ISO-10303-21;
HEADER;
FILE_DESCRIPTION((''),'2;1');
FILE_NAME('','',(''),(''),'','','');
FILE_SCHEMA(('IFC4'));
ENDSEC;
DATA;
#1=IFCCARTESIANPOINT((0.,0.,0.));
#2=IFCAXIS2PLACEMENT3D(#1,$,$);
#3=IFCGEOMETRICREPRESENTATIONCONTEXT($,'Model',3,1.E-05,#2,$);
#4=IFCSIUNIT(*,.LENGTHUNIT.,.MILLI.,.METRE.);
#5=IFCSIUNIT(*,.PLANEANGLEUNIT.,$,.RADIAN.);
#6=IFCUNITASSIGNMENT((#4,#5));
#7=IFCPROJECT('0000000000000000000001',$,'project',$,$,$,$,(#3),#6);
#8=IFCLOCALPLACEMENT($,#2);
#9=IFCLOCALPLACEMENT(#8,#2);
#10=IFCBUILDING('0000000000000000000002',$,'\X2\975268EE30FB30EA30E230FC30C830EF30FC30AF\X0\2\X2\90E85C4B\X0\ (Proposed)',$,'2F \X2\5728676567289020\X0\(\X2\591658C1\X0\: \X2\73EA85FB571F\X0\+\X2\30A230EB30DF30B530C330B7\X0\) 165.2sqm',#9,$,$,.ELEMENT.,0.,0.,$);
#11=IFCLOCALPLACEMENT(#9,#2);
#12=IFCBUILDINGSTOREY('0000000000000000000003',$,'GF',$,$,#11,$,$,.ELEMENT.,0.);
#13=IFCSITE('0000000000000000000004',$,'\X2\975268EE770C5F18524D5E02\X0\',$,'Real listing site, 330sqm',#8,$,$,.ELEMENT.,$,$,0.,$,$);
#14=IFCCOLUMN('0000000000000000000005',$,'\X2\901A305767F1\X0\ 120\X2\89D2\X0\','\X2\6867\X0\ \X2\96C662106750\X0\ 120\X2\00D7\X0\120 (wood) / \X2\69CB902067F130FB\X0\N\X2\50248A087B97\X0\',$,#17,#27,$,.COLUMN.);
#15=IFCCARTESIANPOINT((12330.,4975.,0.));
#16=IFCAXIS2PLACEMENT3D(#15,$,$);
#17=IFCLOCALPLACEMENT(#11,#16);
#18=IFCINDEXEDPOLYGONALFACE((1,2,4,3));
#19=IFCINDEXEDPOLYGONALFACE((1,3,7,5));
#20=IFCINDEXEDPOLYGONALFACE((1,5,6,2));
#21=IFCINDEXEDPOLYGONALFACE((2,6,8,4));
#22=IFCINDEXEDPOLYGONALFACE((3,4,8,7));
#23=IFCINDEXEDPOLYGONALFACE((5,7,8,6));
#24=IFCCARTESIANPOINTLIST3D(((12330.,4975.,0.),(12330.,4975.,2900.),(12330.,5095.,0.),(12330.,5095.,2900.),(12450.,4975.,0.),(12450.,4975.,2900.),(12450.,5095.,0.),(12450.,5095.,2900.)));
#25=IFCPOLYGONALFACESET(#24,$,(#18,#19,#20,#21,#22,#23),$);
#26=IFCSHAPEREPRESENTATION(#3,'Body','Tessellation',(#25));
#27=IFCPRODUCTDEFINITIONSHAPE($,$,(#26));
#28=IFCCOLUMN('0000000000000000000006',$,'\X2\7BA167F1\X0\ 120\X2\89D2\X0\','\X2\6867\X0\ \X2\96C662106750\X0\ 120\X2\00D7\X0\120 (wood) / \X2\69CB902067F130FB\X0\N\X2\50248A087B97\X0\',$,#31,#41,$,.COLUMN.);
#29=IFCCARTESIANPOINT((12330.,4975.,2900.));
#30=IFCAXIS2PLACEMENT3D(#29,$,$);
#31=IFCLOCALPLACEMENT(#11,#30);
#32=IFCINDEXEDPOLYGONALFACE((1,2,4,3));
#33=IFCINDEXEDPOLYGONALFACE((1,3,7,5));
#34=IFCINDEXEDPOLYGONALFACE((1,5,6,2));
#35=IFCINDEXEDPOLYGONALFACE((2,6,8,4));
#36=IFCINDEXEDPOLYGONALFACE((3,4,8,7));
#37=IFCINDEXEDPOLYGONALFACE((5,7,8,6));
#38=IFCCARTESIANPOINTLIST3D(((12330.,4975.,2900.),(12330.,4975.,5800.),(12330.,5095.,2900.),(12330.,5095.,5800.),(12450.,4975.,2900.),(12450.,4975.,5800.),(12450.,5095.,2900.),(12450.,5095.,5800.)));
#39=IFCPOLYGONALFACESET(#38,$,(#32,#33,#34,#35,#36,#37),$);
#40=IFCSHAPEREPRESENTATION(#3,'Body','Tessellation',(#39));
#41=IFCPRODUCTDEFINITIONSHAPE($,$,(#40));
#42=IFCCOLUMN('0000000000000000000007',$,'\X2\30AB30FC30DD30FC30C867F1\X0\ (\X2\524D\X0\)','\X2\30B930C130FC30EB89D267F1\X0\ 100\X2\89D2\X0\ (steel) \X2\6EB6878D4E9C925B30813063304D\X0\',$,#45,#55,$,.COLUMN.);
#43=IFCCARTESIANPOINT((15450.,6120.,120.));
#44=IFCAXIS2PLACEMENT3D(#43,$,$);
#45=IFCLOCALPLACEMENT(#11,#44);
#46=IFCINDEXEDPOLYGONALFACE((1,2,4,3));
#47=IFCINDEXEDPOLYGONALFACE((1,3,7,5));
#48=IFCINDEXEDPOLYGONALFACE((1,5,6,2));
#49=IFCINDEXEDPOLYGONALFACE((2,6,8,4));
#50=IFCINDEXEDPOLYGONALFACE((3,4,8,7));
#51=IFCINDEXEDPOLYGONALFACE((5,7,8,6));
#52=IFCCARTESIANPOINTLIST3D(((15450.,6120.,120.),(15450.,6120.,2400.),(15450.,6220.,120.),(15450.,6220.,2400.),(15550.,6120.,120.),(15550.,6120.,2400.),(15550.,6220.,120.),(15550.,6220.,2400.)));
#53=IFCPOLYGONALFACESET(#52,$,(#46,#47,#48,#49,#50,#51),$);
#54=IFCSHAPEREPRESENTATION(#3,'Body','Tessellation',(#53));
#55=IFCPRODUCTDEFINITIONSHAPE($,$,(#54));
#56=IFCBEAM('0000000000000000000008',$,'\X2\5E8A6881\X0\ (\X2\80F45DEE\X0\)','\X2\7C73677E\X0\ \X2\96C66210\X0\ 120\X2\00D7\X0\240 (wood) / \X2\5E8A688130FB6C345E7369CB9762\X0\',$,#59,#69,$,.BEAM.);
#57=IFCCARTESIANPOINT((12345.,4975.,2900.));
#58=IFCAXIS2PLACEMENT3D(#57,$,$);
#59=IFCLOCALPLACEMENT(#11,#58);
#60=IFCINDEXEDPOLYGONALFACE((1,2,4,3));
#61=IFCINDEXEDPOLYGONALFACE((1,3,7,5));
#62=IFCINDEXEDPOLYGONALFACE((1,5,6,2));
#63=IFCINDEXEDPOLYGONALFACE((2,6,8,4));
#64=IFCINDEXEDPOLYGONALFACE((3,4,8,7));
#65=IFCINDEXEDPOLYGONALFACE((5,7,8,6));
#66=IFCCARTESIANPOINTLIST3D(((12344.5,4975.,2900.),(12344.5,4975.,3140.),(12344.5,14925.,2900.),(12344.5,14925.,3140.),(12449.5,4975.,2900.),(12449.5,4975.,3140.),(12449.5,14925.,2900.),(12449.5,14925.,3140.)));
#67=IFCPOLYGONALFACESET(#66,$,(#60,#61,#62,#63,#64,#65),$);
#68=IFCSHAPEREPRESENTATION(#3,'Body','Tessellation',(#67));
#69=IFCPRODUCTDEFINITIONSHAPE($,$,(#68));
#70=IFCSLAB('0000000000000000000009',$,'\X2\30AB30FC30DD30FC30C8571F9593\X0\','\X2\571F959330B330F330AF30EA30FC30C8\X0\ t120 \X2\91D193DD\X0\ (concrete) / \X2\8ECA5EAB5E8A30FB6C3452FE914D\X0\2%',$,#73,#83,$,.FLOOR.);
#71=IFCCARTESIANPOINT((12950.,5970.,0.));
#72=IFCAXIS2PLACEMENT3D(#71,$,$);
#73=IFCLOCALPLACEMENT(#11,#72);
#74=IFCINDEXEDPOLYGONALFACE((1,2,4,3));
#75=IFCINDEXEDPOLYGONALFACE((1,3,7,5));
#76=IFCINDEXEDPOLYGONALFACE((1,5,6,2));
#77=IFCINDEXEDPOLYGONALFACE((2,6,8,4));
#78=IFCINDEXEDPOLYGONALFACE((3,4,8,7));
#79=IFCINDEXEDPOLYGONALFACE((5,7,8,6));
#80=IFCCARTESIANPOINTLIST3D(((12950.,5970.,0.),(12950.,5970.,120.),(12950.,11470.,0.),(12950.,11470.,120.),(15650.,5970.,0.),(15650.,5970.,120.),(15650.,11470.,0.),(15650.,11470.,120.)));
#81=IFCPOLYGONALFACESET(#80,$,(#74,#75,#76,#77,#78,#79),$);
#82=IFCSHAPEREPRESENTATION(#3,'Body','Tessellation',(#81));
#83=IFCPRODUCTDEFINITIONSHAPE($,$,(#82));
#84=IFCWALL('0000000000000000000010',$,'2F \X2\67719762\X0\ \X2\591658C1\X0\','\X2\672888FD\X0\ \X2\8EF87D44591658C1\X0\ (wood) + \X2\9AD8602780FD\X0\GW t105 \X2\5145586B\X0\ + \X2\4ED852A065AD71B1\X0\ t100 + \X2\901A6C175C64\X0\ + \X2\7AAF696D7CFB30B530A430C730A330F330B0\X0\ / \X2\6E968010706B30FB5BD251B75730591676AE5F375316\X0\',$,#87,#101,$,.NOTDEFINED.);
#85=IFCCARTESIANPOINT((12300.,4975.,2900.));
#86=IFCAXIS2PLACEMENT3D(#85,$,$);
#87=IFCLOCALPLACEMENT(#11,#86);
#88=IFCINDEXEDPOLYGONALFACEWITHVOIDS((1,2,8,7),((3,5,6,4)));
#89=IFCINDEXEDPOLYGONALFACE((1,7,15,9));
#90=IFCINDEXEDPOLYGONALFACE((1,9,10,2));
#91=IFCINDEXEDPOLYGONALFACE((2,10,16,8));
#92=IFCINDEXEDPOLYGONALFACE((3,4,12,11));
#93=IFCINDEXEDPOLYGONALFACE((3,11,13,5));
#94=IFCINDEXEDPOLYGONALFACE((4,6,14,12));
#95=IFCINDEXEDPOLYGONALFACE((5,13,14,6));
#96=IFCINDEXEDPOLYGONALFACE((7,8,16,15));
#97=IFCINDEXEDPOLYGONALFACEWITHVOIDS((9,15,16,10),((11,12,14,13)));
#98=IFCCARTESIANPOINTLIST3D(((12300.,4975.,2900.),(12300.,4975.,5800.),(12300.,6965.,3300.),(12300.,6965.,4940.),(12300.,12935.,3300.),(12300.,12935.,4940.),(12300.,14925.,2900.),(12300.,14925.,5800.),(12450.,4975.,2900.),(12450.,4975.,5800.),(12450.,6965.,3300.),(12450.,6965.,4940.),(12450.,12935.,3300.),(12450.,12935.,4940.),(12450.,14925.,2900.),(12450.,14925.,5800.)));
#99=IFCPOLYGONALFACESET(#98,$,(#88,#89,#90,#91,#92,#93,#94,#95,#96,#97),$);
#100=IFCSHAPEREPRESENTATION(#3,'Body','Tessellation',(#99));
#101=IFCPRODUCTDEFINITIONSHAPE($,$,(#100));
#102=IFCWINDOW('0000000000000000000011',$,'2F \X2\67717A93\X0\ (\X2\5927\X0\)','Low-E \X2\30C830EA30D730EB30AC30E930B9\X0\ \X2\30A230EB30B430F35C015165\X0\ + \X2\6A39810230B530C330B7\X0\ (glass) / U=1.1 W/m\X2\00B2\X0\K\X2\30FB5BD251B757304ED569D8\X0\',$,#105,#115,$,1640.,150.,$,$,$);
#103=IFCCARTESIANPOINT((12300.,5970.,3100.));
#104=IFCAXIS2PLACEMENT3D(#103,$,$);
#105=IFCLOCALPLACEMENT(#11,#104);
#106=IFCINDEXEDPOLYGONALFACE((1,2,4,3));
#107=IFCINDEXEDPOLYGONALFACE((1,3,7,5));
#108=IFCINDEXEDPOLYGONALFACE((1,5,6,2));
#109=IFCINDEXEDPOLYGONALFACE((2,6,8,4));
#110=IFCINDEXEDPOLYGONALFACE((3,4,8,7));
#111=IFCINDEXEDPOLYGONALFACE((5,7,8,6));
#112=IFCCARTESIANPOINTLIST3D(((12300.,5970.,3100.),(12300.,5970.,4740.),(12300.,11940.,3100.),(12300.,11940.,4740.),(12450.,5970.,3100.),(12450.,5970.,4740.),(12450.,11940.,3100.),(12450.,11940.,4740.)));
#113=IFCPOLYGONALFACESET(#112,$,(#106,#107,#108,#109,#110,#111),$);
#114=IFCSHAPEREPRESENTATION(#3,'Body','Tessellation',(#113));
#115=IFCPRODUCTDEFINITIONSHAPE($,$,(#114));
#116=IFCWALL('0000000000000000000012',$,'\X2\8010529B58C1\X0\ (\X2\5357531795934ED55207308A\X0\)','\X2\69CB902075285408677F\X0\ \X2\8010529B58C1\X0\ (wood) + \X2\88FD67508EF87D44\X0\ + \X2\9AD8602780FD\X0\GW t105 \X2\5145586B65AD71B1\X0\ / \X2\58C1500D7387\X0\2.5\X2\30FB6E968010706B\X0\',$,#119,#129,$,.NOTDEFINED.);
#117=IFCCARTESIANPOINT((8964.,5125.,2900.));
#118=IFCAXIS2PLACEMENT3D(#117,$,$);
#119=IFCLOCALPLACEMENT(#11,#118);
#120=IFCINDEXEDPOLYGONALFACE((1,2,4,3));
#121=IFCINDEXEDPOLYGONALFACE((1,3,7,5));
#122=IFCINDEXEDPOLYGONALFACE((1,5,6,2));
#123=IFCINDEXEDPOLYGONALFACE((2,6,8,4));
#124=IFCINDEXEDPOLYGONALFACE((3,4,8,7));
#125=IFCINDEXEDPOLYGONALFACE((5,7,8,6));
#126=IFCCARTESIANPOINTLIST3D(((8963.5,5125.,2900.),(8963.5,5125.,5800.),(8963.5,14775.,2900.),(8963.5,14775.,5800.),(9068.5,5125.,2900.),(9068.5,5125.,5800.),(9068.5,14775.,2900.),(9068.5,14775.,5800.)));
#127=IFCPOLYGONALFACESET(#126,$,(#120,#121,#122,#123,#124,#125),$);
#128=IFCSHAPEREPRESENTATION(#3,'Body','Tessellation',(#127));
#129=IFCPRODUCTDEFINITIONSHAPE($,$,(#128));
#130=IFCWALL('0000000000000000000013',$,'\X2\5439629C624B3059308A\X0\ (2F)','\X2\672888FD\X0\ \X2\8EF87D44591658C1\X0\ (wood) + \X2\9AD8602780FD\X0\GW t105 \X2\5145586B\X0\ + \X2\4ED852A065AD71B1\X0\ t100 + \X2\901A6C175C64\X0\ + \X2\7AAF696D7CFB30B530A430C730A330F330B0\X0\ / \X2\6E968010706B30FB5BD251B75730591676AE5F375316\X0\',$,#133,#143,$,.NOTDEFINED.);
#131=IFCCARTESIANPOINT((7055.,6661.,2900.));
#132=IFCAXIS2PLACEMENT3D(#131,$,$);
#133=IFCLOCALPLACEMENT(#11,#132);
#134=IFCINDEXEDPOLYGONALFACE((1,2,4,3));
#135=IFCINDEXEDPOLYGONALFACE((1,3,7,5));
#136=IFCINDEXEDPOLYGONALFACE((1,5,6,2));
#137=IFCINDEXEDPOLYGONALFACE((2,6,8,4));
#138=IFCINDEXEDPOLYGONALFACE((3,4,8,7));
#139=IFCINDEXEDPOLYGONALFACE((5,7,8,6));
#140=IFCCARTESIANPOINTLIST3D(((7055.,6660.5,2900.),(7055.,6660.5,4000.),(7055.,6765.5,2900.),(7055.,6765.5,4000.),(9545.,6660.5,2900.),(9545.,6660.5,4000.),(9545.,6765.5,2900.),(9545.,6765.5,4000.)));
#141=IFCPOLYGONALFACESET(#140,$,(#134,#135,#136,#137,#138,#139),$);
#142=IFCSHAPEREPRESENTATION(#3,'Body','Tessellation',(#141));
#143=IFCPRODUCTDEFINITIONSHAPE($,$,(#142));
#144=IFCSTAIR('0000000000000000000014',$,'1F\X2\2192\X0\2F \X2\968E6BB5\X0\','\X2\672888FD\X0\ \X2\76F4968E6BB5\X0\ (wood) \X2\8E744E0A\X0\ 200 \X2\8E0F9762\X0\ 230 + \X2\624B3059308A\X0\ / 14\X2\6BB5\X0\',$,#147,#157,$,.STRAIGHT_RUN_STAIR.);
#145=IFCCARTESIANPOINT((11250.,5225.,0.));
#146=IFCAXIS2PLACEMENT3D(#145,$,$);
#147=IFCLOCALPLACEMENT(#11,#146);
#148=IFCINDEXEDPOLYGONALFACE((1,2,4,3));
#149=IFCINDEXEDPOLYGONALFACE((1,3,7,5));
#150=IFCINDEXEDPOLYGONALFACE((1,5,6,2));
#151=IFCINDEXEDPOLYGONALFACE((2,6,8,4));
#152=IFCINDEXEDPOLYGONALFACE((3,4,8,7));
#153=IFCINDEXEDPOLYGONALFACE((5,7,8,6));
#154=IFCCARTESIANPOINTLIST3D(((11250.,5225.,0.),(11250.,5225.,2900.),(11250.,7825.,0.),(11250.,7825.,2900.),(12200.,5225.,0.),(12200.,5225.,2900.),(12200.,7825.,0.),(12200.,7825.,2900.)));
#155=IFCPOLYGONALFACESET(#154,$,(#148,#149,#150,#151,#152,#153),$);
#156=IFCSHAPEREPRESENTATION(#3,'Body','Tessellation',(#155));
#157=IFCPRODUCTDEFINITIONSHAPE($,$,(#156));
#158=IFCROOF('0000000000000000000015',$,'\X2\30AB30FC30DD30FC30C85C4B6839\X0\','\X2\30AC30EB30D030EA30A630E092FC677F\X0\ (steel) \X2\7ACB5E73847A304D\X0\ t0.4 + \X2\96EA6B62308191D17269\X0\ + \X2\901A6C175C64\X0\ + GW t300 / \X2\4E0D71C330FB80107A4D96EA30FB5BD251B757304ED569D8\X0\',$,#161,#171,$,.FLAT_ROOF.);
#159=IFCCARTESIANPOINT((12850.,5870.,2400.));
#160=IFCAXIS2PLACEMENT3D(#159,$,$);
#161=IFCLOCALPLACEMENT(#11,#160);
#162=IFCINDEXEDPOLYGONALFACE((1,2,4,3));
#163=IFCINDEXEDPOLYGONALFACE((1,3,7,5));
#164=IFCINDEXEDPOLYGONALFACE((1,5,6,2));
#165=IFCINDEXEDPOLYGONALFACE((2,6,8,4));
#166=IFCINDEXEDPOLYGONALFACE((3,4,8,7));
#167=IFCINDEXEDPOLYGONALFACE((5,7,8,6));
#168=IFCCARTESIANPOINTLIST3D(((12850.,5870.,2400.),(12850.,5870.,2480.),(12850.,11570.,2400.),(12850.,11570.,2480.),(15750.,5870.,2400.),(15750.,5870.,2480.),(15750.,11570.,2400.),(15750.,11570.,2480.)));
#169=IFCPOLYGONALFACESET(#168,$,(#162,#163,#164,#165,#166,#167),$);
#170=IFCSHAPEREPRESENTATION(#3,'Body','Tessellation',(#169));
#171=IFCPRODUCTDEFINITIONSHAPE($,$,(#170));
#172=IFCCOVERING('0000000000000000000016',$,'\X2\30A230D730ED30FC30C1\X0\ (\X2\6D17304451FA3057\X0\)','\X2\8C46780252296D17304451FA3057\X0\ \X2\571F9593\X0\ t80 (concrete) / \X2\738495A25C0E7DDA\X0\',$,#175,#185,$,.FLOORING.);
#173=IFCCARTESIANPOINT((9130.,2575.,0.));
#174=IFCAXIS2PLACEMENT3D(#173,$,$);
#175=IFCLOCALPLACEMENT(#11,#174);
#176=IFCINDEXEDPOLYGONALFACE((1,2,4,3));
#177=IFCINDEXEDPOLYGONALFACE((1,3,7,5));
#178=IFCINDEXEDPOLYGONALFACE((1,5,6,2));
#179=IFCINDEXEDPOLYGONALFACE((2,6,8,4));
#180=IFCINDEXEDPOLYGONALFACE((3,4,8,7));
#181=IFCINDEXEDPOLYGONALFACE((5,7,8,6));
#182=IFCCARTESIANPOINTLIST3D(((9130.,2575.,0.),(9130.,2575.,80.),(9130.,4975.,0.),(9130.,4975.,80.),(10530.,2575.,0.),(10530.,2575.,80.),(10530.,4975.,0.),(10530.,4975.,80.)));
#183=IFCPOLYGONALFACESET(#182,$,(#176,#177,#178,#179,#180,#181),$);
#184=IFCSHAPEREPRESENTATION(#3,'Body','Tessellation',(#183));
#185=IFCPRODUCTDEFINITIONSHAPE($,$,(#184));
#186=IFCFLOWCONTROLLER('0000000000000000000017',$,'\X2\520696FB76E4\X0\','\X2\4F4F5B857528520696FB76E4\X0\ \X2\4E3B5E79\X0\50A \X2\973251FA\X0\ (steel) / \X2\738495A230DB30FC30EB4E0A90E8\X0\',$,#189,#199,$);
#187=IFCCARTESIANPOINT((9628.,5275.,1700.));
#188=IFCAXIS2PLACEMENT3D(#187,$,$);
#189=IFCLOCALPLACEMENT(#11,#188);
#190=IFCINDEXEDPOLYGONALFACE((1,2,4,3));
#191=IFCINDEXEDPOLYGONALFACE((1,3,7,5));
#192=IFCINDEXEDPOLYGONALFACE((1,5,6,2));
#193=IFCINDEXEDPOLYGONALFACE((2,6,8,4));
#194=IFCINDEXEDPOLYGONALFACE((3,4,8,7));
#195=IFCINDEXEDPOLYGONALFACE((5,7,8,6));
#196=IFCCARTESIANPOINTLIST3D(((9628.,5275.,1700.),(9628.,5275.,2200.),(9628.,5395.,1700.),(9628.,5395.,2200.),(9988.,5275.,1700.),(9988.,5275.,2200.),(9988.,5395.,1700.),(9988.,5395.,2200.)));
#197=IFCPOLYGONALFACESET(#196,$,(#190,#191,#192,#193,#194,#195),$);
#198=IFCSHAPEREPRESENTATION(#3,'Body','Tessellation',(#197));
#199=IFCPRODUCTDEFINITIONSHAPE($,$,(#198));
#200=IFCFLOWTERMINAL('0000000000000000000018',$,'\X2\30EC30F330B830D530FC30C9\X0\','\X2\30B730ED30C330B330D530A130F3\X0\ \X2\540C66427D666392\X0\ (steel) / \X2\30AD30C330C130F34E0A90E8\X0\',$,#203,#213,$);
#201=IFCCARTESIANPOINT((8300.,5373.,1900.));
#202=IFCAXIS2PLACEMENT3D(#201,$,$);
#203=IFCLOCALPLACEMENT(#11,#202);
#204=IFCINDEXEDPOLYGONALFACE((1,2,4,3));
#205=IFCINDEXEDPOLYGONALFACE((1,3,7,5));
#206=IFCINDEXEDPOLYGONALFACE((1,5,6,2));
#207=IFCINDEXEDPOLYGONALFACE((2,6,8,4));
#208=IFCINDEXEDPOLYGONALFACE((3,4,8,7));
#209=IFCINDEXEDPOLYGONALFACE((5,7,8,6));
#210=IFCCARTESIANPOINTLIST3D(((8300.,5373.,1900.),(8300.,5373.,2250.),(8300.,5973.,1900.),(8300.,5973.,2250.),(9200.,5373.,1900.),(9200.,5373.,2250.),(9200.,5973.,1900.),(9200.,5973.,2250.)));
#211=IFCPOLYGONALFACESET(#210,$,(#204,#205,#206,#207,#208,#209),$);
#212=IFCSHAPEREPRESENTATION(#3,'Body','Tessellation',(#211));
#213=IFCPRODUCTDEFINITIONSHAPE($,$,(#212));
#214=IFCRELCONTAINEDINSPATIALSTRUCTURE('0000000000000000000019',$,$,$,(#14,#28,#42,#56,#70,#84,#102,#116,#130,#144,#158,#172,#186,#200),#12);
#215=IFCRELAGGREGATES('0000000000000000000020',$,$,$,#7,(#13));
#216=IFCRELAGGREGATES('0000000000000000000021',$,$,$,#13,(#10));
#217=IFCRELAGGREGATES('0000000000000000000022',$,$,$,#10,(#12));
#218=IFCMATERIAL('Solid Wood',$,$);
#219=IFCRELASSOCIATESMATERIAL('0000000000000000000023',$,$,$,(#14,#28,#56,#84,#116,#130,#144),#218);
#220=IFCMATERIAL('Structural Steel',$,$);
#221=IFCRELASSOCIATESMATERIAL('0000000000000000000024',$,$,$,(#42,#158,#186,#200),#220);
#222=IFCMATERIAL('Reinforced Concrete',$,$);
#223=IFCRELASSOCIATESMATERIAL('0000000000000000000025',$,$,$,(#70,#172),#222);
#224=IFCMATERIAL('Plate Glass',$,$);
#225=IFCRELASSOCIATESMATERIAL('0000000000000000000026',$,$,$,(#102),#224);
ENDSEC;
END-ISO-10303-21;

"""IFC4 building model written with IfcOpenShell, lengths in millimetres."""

from ifc_helpers import new_model, si_unit, frame, frame_2d, origin, place, context, project, spatial, rectangle, extrude, material, element, fill, save


model = new_model("IFC4")

# Units and contexts
model_context = context("Model", 3, precision=1e-05, world=origin())
ifc_project = project(units=[si_unit("LENGTHUNIT", "METRE", prefix="MILLI"), si_unit("PLANEANGLEUNIT", "RADIAN")], contexts=[model_context])

# Site, building, storey
site_placement = place(None, origin())
site = spatial("IfcSite", under=ifc_project, at=site_placement, Name="青森県弘前市", ObjectType="Real listing site, 330sqm", CompositionType="ELEMENT", RefElevation=0.0)
building_placement = place(site_placement, origin())
building = spatial("IfcBuilding", under=site, at=building_placement, Name="青森・リモートワーク2部屋 (Proposed)", ObjectType="2F 在来木造(外壁: 珪藻土+アルミサッシ) 165.2sqm", CompositionType="ELEMENT", ElevationOfRefHeight=0.0, ElevationOfTerrain=0.0)
storey_placement = place(building_placement, origin())
storey = spatial("IfcBuildingStorey", under=building, at=storey_placement, Name="GF", CompositionType="ELEMENT", Elevation=0.0)

# Columns
ifc_material_1 = material(Name="Solid Wood")
column_1_placement = place(storey_placement, frame((12330.0, 4975.0, 0.0)))
element("IfcColumn", 1, at=column_1_placement, inside=storey, material=ifc_material_1, Name="通し柱 120角", Description="桧 集成材 120×120 (wood) / 構造柱・N値計算", PredefinedType="COLUMN", context=model_context, shape_type="SweptSolid", body=[
    extrude(rectangle(XDim=120.0, YDim=120.0, at=frame_2d((60.0, 60.0))), frame((12330.0, 4975.0, 0.0)), (0.0, 0.0, 1.0), 2900.0),
])
column_2_placement = place(storey_placement, frame((12330.0, 4975.0, 2900.0)))
element("IfcColumn", 2, at=column_2_placement, inside=storey, material=ifc_material_1, Name="管柱 120角", Description="桧 集成材 120×120 (wood) / 構造柱・N値計算", PredefinedType="COLUMN", context=model_context, shape_type="SweptSolid", body=[
    extrude(rectangle(XDim=120.0, YDim=120.0, at=frame_2d((60.0, 60.0))), frame((12330.0, 4975.0, 2900.0)), (0.0, 0.0, 1.0), 2900.0),
])
ifc_material_2 = material(Name="Structural Steel")
column_3_placement = place(storey_placement, frame((15450.0, 6120.0, 120.0)))
element("IfcColumn", 3, at=column_3_placement, inside=storey, material=ifc_material_2, Name="カーポート柱 (前)", Description="スチール角柱 100角 (steel) 溶融亜鉛めっき", PredefinedType="COLUMN", context=model_context, shape_type="SweptSolid", body=[
    extrude(rectangle(XDim=100.0, YDim=100.0, at=frame_2d((50.0, 50.0))), frame((15450.0, 6120.0, 120.0)), (0.0, 0.0, 1.0), 2280.0),
])

# Beam
beam_1_placement = place(storey_placement, frame((12345.0, 4975.0, 2900.0)))
element("IfcBeam", 4, at=beam_1_placement, inside=storey, material=ifc_material_1, Name="床梁 (胴差)", Description="米松 集成 120×240 (wood) / 床梁・水平構面", PredefinedType="BEAM", context=model_context, shape_type="SweptSolid", body=[
    extrude(rectangle(XDim=105.0, YDim=9950.0, at=frame_2d((52.0, 4975.0))), frame((12345.0, 4975.0, 2900.0)), (0.0, 0.0, 1.0), 240.0),
])

# Slab
ifc_material_3 = material(Name="Reinforced Concrete")
slab_placement = place(storey_placement, frame((12950.0, 5970.0, 0.0)))
element("IfcSlab", 5, at=slab_placement, inside=storey, material=ifc_material_3, Name="カーポート土間", Description="土間コンクリート t120 金鏝 (concrete) / 車庫床・水勾配2%", PredefinedType="FLOOR", context=model_context, shape_type="SweptSolid", body=[
    extrude(rectangle(XDim=2700.0, YDim=5500.0, at=frame_2d((1350.0, 2750.0))), frame((12950.0, 5970.0, 0.0)), (0.0, 0.0, 1.0), 120.0),
])

# Shared definitions
ifc_material_4 = material(Name="Plate Glass")

# Wall, opening, window
wall_1_placement = place(storey_placement, frame((12300.0, 4975.0, 2900.0)))
wall_1 = element("IfcWall", 6, at=wall_1_placement, inside=storey, material=ifc_material_1, Name="2F 東面 外壁", Description="木製 軸組外壁 (wood) + 高性能GW t105 充填 + 付加断熱 t100 + 通気層 + 窯業系サイディング / 準耐火・寒冷地外皮強化", PredefinedType="NOTDEFINED", context=model_context, shape_type="SweptSolid", body=[
    extrude(rectangle(XDim=150.0, YDim=9950.0, at=frame_2d((75.0, 4975.0))), frame((12300.0, 4975.0, 2900.0)), (0.0, 0.0, 1.0), 2900.0),
])
opening_1_placement = place(storey_placement, frame((12300.0, 5970.0, 3100.0)))
opening_1 = element("IfcOpeningElement", 7, at=opening_1_placement, cuts=wall_1, PredefinedType="NOTDEFINED", context=model_context, shape_type="SweptSolid", body=[
    extrude(rectangle(XDim=150.0, YDim=5970.0, at=frame_2d((75.0, 2985.0))), frame((12300.0, 5970.0, 3100.0)), (0.0, 0.0, 1.0), 1640.0),
])
window_1_placement = place(storey_placement, frame((12300.0, 5970.0, 3100.0)))
window_1 = element("IfcWindow", 8, at=window_1_placement, inside=storey, material=ifc_material_4, Name="2F 東窓 (大)", Description="Low-E トリプルガラス アルゴン封入 + 樹脂サッシ (glass) / U=1.1 W/m²K・寒冷地仕様", OverallHeight=1640.0, OverallWidth=150.0, context=model_context, shape_type="SweptSolid", body=[
    extrude(rectangle(XDim=150.0, YDim=5970.0, at=frame_2d((75.0, 2985.0))), frame((12300.0, 5970.0, 3100.0)), (0.0, 0.0, 1.0), 1640.0),
])
fill(opening_1, window_1)

# Walls
wall_2_placement = place(storey_placement, frame((8964.0, 5125.0, 2900.0)))
element("IfcWall", 9, at=wall_2_placement, inside=storey, material=ifc_material_1, Name="耐力壁 (南北間仕切り)", Description="構造用合板 耐力壁 (wood) + 製材軸組 + 高性能GW t105 充填断熱 / 壁倍率2.5・準耐火", PredefinedType="NOTDEFINED", context=model_context, shape_type="SweptSolid", body=[
    extrude(rectangle(XDim=105.0, YDim=9650.0, at=frame_2d((52.0, 4825.0))), frame((8964.0, 5125.0, 2900.0)), (0.0, 0.0, 1.0), 2900.0),
])
wall_3_placement = place(storey_placement, frame((7055.0, 6661.0, 2900.0)))
element("IfcWall", 10, at=wall_3_placement, inside=storey, material=ifc_material_1, Name="吹抜手すり (2F)", Description="木製 軸組外壁 (wood) + 高性能GW t105 充填 + 付加断熱 t100 + 通気層 + 窯業系サイディング / 準耐火・寒冷地外皮強化", PredefinedType="NOTDEFINED", context=model_context, shape_type="SweptSolid", body=[
    extrude(rectangle(XDim=2490.0, YDim=105.0, at=frame_2d((1245.0, 52.0))), frame((7055.0, 6661.0, 2900.0)), (0.0, 0.0, 1.0), 1100.0),
])

# Stair
stair_placement = place(storey_placement, frame((11250.0, 5225.0, 0.0)))
element("IfcStair", 11, at=stair_placement, inside=storey, material=ifc_material_1, Name="1F→2F 階段", Description="木製 直階段 (wood) 蹴上 200 踏面 230 + 手すり / 14段", PredefinedType="STRAIGHT_RUN_STAIR", context=model_context, shape_type="SweptSolid", body=[
    extrude(rectangle(XDim=950.0, YDim=2600.0, at=frame_2d((475.0, 1300.0))), frame((11250.0, 5225.0, 0.0)), (0.0, 0.0, 1.0), 2900.0),
])

# Roof
roof_placement = place(storey_placement, frame((12850.0, 5870.0, 2400.0)))
element("IfcRoof", 12, at=roof_placement, inside=storey, material=ifc_material_2, Name="カーポート屋根", Description="ガルバリウム鋼板 (steel) 立平葺き t0.4 + 雪止め金物 + 通気層 + GW t300 / 不燃・耐積雪・寒冷地仕様", PredefinedType="FLAT_ROOF", context=model_context, shape_type="SweptSolid", body=[
    extrude(rectangle(XDim=2900.0, YDim=5700.0, at=frame_2d((1450.0, 2850.0))), frame((12850.0, 5870.0, 2400.0)), (0.0, 0.0, 1.0), 80.0),
])

# Covering
covering_placement = place(storey_placement, frame((9130.0, 2575.0, 0.0)))
element("IfcCovering", 13, at=covering_placement, inside=storey, material=ifc_material_3, Name="アプローチ (洗い出し)", Description="豆砂利洗い出し 土間 t80 (concrete) / 玄関導線", PredefinedType="FLOORING", context=model_context, shape_type="SweptSolid", body=[
    extrude(rectangle(XDim=1400.0, YDim=2400.0, at=frame_2d((700.0, 1200.0))), frame((9130.0, 2575.0, 0.0)), (0.0, 0.0, 1.0), 80.0),
])

# Flow controller
flow_controller_placement = place(storey_placement, frame((9628.0, 5275.0, 1700.0)))
element("IfcFlowController", 14, at=flow_controller_placement, inside=storey, material=ifc_material_2, Name="分電盤", Description="住宅用分電盤 主幹50A 露出 (steel) / 玄関ホール上部", context=model_context, shape_type="SweptSolid", body=[
    extrude(rectangle(XDim=360.0, YDim=120.0, at=frame_2d((180.0, 60.0))), frame((9628.0, 5275.0, 1700.0)), (0.0, 0.0, 1.0), 500.0),
])

# Flow terminal
flow_terminal_1_placement = place(storey_placement, frame((8300.0, 5373.0, 1900.0)))
element("IfcFlowTerminal", 15, at=flow_terminal_1_placement, inside=storey, material=ifc_material_2, Name="レンジフード", Description="シロッコファン 同時給排 (steel) / キッチン上部", context=model_context, shape_type="SweptSolid", body=[
    extrude(rectangle(XDim=900.0, YDim=600.0, at=frame_2d((450.0, 300.0))), frame((8300.0, 5373.0, 1900.0)), (0.0, 0.0, 1.0), 350.0),
])

save(model, "model.ifc")
